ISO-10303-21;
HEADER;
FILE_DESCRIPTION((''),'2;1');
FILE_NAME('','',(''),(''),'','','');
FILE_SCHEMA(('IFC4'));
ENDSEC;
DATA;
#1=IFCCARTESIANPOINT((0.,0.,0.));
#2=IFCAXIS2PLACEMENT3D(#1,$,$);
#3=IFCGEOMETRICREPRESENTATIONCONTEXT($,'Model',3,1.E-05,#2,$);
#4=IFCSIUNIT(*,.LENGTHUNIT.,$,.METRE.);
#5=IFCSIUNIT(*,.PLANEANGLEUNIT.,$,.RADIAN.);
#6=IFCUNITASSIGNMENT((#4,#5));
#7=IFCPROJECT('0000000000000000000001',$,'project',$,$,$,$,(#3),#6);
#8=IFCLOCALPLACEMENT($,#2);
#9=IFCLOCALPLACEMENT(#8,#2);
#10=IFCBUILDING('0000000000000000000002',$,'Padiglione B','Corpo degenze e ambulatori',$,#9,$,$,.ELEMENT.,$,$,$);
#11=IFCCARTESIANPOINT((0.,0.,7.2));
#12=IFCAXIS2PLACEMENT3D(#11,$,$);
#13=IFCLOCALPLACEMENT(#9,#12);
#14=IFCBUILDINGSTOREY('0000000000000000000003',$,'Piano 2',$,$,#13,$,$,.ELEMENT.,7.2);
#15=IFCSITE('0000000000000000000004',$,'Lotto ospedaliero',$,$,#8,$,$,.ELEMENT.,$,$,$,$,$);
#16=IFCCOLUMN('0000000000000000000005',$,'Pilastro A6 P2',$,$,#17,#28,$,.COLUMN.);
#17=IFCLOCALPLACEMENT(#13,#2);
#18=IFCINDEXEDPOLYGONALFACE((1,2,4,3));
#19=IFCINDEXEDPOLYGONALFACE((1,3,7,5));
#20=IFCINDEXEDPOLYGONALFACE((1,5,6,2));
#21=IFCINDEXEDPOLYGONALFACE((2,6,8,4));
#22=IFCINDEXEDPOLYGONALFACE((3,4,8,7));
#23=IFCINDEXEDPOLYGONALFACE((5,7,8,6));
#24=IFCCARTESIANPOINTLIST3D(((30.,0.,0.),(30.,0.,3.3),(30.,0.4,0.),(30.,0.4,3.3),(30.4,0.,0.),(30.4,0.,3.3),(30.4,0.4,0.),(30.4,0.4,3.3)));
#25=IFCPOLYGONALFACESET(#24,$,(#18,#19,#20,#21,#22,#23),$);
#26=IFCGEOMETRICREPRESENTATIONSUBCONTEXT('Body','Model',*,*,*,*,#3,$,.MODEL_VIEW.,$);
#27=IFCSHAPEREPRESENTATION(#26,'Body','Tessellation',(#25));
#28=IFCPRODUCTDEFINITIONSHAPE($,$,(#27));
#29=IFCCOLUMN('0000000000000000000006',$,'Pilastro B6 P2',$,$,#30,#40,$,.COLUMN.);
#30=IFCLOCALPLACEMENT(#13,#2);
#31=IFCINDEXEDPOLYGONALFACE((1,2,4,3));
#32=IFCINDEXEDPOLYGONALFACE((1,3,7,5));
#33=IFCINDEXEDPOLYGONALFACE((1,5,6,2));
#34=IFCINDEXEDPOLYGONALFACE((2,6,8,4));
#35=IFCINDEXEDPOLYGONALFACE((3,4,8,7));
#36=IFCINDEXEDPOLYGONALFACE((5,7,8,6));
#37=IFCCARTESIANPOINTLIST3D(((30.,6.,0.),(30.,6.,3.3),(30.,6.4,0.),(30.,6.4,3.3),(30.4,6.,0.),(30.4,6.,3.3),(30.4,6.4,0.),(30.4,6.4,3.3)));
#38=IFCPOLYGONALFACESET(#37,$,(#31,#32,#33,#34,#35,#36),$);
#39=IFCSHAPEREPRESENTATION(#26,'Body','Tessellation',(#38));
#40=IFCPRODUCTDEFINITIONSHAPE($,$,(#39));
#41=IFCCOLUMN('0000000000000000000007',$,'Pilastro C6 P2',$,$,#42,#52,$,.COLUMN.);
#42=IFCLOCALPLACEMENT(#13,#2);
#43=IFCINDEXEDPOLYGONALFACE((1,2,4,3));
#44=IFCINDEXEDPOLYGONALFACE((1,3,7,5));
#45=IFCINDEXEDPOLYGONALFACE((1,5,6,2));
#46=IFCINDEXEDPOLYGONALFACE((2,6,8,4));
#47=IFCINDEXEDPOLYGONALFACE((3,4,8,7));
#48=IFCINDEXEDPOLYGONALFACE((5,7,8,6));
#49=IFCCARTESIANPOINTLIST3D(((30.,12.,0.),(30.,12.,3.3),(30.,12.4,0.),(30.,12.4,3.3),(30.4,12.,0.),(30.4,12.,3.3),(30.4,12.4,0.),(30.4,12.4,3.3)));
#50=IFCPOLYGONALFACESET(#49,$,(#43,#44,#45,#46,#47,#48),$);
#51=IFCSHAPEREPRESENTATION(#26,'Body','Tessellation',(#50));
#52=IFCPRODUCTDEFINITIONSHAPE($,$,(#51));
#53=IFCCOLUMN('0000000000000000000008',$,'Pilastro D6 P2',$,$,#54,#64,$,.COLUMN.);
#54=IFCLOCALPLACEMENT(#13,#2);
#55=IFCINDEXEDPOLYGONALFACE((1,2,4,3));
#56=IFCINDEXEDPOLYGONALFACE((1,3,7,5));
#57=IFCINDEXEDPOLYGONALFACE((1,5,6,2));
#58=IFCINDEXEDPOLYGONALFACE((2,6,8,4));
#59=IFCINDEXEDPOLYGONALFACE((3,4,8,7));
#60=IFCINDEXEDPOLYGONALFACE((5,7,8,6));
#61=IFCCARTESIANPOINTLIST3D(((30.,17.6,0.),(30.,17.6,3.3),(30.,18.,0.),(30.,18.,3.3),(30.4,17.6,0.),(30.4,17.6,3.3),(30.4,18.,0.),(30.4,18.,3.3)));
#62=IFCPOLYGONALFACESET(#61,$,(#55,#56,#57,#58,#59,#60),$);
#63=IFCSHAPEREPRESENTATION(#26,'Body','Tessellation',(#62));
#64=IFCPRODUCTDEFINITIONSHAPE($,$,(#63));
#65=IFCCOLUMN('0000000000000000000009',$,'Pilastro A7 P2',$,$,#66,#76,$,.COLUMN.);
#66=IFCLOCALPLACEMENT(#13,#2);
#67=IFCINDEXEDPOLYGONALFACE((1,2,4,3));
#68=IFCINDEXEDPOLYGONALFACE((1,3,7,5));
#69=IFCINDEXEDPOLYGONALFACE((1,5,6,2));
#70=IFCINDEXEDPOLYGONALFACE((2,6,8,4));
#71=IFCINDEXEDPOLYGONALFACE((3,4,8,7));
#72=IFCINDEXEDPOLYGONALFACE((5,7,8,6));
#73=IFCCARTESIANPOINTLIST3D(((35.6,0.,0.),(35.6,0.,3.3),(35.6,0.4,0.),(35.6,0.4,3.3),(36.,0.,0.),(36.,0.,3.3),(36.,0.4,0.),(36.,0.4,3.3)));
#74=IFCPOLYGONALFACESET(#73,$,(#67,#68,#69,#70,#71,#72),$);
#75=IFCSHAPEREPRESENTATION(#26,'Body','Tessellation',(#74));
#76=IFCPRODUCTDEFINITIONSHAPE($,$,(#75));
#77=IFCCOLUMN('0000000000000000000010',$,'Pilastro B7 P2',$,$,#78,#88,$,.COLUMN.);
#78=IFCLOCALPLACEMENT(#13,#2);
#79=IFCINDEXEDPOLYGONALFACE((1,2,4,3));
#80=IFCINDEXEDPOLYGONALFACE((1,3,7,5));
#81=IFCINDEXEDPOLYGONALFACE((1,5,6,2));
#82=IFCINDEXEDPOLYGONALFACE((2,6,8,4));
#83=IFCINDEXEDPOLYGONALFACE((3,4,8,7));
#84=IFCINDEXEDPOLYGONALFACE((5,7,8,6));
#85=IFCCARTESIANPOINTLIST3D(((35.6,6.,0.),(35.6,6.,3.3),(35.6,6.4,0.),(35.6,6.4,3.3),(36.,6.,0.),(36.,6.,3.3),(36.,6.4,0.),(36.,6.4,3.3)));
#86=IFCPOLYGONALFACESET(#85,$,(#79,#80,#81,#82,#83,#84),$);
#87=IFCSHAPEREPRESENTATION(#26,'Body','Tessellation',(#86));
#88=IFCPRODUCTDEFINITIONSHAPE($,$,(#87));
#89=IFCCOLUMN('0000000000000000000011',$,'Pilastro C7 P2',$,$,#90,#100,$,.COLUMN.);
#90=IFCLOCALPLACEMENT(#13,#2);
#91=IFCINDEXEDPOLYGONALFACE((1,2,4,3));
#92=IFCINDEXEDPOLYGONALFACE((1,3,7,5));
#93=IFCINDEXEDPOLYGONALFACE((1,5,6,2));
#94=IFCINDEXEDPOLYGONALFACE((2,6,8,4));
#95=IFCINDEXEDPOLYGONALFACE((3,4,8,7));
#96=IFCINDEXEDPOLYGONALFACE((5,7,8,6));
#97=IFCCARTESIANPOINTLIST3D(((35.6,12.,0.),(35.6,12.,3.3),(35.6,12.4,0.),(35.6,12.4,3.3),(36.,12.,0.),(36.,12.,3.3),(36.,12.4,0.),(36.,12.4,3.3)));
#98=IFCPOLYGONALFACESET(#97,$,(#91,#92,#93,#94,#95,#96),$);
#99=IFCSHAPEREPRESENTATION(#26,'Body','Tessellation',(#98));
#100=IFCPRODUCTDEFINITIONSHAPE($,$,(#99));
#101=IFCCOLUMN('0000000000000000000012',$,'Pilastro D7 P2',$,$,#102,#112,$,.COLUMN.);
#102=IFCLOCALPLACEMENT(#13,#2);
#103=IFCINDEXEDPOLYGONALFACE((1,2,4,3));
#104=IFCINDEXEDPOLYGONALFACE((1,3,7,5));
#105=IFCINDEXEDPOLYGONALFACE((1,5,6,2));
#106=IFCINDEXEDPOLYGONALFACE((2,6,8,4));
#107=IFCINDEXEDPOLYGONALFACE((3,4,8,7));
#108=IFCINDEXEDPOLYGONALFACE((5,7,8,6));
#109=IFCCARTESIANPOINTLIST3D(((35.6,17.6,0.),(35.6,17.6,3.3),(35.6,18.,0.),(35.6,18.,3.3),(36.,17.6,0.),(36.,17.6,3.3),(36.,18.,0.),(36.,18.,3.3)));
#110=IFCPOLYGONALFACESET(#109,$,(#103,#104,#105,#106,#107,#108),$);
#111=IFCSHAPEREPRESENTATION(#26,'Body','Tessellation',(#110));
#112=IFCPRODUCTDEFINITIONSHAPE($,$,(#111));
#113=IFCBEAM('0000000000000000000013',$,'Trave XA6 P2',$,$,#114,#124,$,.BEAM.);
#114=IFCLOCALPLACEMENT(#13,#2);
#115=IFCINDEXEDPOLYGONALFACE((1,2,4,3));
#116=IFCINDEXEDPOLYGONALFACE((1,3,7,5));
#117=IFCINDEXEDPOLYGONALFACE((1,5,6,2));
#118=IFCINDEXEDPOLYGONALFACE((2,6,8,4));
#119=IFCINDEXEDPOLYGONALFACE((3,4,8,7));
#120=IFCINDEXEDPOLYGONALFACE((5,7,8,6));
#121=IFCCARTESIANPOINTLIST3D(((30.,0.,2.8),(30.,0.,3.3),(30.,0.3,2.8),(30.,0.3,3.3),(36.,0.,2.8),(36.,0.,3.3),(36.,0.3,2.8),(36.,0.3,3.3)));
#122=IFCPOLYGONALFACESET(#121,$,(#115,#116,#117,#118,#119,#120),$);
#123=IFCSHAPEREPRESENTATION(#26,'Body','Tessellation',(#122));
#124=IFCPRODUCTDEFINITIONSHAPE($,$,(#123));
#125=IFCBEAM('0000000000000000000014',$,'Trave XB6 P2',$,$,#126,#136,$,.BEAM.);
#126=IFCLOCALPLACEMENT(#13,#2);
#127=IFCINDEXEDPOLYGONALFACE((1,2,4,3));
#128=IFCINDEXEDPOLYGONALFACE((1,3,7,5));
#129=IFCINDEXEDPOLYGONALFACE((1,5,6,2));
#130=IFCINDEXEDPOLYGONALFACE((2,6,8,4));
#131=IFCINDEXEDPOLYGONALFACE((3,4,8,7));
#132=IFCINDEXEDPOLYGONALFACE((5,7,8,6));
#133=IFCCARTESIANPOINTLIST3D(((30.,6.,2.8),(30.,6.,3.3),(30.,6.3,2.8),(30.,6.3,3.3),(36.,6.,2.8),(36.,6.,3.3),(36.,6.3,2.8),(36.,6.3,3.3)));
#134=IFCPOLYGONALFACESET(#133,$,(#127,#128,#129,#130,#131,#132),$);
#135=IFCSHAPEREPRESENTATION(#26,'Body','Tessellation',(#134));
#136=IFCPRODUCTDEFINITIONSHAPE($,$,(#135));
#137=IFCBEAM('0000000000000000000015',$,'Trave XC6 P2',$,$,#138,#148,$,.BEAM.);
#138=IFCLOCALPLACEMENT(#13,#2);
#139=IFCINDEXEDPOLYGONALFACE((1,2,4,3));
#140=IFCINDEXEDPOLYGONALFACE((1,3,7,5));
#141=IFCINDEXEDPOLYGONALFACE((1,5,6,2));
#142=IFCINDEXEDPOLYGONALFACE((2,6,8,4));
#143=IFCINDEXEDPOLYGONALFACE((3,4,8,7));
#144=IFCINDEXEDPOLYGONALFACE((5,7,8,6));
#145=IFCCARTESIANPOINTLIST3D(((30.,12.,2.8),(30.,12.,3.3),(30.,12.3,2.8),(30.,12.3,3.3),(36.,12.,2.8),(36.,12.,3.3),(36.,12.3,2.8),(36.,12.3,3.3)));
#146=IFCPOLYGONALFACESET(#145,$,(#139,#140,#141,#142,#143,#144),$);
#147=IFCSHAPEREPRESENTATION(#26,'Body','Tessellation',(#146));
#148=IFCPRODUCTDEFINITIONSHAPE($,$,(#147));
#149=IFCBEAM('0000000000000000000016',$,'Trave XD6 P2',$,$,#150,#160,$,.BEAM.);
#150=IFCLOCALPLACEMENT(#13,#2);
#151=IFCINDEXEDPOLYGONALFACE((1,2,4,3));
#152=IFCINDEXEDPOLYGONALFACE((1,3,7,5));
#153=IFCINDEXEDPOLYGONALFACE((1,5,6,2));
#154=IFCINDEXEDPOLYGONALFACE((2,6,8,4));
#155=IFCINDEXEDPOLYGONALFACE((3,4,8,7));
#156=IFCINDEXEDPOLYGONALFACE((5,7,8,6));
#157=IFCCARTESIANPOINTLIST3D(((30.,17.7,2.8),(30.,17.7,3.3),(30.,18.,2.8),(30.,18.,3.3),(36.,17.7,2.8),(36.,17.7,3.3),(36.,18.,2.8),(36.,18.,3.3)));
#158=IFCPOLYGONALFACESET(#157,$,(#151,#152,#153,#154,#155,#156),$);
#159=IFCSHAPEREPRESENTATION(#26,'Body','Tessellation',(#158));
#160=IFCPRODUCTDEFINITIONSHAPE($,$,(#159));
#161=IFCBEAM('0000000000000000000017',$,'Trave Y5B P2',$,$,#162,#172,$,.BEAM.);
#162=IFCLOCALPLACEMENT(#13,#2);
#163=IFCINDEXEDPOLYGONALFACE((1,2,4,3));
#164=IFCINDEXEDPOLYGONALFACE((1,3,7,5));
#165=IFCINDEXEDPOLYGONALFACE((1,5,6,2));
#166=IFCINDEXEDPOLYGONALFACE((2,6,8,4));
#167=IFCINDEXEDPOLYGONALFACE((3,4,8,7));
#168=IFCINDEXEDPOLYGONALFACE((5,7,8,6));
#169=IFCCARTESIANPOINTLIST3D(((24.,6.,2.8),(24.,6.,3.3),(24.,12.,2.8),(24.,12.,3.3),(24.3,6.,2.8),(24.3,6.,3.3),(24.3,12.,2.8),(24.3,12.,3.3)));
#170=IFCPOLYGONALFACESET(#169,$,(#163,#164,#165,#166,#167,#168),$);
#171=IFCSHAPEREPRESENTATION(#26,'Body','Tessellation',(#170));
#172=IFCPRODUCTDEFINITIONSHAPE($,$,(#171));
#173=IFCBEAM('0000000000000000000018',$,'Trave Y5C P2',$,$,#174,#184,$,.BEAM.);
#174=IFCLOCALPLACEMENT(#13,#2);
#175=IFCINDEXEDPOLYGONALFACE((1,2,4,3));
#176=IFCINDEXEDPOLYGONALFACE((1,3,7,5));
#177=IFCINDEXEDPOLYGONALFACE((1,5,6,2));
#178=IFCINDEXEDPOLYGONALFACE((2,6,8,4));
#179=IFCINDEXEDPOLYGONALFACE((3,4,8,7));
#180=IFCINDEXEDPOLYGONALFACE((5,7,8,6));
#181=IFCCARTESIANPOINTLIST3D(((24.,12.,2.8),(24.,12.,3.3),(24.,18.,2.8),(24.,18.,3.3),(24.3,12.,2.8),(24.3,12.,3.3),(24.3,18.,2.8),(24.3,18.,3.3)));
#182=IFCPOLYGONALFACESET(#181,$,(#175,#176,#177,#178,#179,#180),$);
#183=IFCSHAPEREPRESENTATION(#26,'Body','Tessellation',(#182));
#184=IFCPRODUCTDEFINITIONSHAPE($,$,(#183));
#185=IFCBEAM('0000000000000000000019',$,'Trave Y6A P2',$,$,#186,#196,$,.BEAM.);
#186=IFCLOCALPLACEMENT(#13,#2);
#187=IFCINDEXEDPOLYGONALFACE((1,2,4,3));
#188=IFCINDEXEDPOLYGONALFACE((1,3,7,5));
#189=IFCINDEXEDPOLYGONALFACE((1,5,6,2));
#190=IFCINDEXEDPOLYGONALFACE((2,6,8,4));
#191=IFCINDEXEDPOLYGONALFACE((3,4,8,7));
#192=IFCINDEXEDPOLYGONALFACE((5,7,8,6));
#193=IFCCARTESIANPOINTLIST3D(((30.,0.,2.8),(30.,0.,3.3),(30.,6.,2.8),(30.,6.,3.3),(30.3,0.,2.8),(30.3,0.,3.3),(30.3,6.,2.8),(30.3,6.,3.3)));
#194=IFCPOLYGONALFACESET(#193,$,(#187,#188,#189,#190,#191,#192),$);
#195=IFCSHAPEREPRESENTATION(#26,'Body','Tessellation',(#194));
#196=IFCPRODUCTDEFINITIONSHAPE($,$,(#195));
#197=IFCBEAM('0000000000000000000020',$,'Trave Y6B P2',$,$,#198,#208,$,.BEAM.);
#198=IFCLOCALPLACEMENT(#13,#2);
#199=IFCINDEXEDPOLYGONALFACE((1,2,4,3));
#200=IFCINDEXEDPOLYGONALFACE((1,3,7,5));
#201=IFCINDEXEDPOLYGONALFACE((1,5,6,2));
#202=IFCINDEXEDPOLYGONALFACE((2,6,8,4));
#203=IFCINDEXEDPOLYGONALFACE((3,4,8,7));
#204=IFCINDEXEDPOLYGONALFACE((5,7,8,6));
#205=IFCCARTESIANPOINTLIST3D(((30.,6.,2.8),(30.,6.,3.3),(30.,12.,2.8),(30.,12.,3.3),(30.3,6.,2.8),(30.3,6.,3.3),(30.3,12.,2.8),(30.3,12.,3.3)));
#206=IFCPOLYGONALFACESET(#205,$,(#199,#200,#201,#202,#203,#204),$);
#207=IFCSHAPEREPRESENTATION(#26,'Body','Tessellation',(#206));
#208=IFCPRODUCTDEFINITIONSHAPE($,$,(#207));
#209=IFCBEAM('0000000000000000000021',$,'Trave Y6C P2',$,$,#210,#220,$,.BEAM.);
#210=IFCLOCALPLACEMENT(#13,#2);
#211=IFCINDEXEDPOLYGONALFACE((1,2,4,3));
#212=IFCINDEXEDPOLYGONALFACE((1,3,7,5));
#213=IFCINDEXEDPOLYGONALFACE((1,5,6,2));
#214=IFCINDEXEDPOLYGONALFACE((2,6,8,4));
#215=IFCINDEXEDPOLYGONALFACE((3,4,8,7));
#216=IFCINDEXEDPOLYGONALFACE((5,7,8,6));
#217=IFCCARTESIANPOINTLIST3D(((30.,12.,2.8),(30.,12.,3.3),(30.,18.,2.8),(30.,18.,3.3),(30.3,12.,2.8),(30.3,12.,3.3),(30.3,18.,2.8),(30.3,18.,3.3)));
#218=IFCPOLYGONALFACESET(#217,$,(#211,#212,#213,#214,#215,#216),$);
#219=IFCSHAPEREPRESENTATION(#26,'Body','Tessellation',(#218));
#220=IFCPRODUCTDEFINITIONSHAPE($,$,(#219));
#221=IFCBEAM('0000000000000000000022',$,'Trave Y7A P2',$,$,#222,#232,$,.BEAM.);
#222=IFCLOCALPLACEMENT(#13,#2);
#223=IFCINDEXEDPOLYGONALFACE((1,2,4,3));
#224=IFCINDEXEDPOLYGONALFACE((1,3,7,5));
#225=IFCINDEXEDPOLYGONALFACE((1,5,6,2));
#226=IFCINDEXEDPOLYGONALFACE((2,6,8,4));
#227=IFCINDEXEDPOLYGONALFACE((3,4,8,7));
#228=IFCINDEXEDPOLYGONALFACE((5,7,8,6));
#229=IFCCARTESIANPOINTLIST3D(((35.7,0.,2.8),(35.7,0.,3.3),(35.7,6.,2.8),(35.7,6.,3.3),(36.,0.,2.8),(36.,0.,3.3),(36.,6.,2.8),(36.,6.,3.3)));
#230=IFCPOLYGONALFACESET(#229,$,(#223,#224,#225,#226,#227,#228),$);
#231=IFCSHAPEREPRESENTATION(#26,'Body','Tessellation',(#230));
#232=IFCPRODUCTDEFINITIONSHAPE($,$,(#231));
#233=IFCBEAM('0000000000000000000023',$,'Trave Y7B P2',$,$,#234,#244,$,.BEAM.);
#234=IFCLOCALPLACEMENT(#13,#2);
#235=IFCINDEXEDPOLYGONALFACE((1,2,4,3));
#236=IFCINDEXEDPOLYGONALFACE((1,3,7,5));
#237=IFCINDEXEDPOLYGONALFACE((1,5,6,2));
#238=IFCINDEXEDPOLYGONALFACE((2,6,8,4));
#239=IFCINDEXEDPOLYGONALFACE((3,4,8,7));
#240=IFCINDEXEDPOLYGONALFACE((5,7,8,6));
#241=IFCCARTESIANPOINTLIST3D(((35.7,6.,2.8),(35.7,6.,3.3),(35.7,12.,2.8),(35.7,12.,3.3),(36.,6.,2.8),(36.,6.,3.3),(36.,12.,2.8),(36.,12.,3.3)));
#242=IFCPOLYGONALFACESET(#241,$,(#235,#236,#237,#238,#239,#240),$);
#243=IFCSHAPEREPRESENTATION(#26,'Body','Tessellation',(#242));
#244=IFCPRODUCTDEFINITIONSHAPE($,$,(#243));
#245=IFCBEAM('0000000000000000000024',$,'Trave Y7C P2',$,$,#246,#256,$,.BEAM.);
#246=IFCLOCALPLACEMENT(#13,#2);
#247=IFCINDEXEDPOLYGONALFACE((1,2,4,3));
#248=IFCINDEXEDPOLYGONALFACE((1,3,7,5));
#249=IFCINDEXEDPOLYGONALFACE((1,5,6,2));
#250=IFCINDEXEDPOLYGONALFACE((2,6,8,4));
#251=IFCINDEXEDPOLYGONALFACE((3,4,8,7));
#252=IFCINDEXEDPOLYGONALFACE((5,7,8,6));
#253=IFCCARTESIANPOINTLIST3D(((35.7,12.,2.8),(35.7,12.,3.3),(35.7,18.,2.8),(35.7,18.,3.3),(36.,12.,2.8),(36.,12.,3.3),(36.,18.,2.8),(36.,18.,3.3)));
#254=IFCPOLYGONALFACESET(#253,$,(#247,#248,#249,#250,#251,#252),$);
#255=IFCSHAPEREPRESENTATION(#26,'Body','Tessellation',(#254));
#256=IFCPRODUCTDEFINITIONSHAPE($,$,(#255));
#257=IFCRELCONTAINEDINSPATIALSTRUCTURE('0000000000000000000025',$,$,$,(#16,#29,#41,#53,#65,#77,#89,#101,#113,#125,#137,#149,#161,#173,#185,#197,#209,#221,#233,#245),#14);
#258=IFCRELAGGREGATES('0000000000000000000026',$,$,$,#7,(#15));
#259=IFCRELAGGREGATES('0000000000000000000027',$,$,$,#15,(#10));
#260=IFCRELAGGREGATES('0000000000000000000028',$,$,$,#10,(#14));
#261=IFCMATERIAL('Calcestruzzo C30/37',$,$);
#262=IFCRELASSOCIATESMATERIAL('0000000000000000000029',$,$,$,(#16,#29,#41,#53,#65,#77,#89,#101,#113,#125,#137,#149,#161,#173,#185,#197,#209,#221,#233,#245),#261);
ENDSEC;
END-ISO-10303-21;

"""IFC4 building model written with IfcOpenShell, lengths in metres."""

from ifc_helpers import new_model, si_unit, frame, frame_2d, origin, place, context, subcontext, project, spatial, rectangle, extrude, material, element, save


model = new_model("IFC4")

# Units and contexts
model_context = context("Model", 3, precision=1e-05, world=origin())
body_context = subcontext(model_context, "Body", "Model", "MODEL_VIEW")
ifc_project = project(units=[si_unit("LENGTHUNIT", "METRE"), si_unit("PLANEANGLEUNIT", "RADIAN")], contexts=[model_context])

# Site, building, storey
site_placement = place(None, origin())
site = spatial("IfcSite", under=ifc_project, at=site_placement, Name="Lotto ospedaliero", CompositionType="ELEMENT")
building_placement = place(site_placement, origin())
building = spatial("IfcBuilding", under=site, at=building_placement, Name="Padiglione B", Description="Corpo degenze e ambulatori", CompositionType="ELEMENT")
storey_placement = place(building_placement, frame((0.0, 0.0, 7.2)))
storey = spatial("IfcBuildingStorey", under=building, at=storey_placement, Name="Piano 2", CompositionType="ELEMENT", Elevation=7.2)

# Columns
ifc_material_1 = material(Name="Calcestruzzo C30/37")
for number, where, name in (
    (1, (30.0, 0.0, 0.0), "Pilastro A6 P2"),
    (2, (30.0, 6.0, 0.0), "Pilastro B6 P2"),
    (3, (30.0, 12.0, 0.0), "Pilastro C6 P2"),
    (4, (30.0, 17.6, 0.0), "Pilastro D6 P2"),
    (5, (35.6, 0.0, 0.0), "Pilastro A7 P2"),
    (6, (35.6, 6.0, 0.0), "Pilastro B7 P2"),
    (7, (35.6, 12.0, 0.0), "Pilastro C7 P2"),
    (8, (35.6, 17.6, 0.0), "Pilastro D7 P2"),
):
    element("IfcColumn", number, at=place(storey_placement, frame(where)), inside=storey, material=ifc_material_1, Name=name, PredefinedType="COLUMN", context=body_context, shape_type="SweptSolid", body=[
        extrude(rectangle(XDim=0.4, YDim=0.4, at=frame_2d((0.2, 0.2))), origin(), (0.0, 0.0, 1.0), 3.3),
    ])

# Beams
for number, where, name in (
    (9, (30.0, 0.0, 2.8), "Trave XA6 P2"),
    (10, (30.0, 6.0, 2.8), "Trave XB6 P2"),
    (11, (30.0, 12.0, 2.8), "Trave XC6 P2"),
    (12, (30.0, 17.7, 2.8), "Trave XD6 P2"),
):
    element("IfcBeam", number, at=place(storey_placement, frame(where)), inside=storey, material=ifc_material_1, Name=name, PredefinedType="BEAM", context=body_context, shape_type="SweptSolid", body=[
        extrude(rectangle(XDim=6.0, YDim=0.3, at=frame_2d((3.0, 0.15))), origin(), (0.0, 0.0, 1.0), 0.5),
    ])
for number, where, name in (
    (13, (24.0, 6.0, 2.8), "Trave Y5B P2"),
    (14, (24.0, 12.0, 2.8), "Trave Y5C P2"),
    (15, (30.0, 0.0, 2.8), "Trave Y6A P2"),
    (16, (30.0, 6.0, 2.8), "Trave Y6B P2"),
    (17, (30.0, 12.0, 2.8), "Trave Y6C P2"),
    (18, (35.7, 0.0, 2.8), "Trave Y7A P2"),
    (19, (35.7, 6.0, 2.8), "Trave Y7B P2"),
    (20, (35.7, 12.0, 2.8), "Trave Y7C P2"),
):
    element("IfcBeam", number, at=place(storey_placement, frame(where)), inside=storey, material=ifc_material_1, Name=name, PredefinedType="BEAM", context=body_context, shape_type="SweptSolid", body=[
        extrude(rectangle(XDim=0.3, YDim=6.0, at=frame_2d((0.15, 3.0))), origin(), (0.0, 0.0, 1.0), 0.5),
    ])

save(model, "model.ifc")
